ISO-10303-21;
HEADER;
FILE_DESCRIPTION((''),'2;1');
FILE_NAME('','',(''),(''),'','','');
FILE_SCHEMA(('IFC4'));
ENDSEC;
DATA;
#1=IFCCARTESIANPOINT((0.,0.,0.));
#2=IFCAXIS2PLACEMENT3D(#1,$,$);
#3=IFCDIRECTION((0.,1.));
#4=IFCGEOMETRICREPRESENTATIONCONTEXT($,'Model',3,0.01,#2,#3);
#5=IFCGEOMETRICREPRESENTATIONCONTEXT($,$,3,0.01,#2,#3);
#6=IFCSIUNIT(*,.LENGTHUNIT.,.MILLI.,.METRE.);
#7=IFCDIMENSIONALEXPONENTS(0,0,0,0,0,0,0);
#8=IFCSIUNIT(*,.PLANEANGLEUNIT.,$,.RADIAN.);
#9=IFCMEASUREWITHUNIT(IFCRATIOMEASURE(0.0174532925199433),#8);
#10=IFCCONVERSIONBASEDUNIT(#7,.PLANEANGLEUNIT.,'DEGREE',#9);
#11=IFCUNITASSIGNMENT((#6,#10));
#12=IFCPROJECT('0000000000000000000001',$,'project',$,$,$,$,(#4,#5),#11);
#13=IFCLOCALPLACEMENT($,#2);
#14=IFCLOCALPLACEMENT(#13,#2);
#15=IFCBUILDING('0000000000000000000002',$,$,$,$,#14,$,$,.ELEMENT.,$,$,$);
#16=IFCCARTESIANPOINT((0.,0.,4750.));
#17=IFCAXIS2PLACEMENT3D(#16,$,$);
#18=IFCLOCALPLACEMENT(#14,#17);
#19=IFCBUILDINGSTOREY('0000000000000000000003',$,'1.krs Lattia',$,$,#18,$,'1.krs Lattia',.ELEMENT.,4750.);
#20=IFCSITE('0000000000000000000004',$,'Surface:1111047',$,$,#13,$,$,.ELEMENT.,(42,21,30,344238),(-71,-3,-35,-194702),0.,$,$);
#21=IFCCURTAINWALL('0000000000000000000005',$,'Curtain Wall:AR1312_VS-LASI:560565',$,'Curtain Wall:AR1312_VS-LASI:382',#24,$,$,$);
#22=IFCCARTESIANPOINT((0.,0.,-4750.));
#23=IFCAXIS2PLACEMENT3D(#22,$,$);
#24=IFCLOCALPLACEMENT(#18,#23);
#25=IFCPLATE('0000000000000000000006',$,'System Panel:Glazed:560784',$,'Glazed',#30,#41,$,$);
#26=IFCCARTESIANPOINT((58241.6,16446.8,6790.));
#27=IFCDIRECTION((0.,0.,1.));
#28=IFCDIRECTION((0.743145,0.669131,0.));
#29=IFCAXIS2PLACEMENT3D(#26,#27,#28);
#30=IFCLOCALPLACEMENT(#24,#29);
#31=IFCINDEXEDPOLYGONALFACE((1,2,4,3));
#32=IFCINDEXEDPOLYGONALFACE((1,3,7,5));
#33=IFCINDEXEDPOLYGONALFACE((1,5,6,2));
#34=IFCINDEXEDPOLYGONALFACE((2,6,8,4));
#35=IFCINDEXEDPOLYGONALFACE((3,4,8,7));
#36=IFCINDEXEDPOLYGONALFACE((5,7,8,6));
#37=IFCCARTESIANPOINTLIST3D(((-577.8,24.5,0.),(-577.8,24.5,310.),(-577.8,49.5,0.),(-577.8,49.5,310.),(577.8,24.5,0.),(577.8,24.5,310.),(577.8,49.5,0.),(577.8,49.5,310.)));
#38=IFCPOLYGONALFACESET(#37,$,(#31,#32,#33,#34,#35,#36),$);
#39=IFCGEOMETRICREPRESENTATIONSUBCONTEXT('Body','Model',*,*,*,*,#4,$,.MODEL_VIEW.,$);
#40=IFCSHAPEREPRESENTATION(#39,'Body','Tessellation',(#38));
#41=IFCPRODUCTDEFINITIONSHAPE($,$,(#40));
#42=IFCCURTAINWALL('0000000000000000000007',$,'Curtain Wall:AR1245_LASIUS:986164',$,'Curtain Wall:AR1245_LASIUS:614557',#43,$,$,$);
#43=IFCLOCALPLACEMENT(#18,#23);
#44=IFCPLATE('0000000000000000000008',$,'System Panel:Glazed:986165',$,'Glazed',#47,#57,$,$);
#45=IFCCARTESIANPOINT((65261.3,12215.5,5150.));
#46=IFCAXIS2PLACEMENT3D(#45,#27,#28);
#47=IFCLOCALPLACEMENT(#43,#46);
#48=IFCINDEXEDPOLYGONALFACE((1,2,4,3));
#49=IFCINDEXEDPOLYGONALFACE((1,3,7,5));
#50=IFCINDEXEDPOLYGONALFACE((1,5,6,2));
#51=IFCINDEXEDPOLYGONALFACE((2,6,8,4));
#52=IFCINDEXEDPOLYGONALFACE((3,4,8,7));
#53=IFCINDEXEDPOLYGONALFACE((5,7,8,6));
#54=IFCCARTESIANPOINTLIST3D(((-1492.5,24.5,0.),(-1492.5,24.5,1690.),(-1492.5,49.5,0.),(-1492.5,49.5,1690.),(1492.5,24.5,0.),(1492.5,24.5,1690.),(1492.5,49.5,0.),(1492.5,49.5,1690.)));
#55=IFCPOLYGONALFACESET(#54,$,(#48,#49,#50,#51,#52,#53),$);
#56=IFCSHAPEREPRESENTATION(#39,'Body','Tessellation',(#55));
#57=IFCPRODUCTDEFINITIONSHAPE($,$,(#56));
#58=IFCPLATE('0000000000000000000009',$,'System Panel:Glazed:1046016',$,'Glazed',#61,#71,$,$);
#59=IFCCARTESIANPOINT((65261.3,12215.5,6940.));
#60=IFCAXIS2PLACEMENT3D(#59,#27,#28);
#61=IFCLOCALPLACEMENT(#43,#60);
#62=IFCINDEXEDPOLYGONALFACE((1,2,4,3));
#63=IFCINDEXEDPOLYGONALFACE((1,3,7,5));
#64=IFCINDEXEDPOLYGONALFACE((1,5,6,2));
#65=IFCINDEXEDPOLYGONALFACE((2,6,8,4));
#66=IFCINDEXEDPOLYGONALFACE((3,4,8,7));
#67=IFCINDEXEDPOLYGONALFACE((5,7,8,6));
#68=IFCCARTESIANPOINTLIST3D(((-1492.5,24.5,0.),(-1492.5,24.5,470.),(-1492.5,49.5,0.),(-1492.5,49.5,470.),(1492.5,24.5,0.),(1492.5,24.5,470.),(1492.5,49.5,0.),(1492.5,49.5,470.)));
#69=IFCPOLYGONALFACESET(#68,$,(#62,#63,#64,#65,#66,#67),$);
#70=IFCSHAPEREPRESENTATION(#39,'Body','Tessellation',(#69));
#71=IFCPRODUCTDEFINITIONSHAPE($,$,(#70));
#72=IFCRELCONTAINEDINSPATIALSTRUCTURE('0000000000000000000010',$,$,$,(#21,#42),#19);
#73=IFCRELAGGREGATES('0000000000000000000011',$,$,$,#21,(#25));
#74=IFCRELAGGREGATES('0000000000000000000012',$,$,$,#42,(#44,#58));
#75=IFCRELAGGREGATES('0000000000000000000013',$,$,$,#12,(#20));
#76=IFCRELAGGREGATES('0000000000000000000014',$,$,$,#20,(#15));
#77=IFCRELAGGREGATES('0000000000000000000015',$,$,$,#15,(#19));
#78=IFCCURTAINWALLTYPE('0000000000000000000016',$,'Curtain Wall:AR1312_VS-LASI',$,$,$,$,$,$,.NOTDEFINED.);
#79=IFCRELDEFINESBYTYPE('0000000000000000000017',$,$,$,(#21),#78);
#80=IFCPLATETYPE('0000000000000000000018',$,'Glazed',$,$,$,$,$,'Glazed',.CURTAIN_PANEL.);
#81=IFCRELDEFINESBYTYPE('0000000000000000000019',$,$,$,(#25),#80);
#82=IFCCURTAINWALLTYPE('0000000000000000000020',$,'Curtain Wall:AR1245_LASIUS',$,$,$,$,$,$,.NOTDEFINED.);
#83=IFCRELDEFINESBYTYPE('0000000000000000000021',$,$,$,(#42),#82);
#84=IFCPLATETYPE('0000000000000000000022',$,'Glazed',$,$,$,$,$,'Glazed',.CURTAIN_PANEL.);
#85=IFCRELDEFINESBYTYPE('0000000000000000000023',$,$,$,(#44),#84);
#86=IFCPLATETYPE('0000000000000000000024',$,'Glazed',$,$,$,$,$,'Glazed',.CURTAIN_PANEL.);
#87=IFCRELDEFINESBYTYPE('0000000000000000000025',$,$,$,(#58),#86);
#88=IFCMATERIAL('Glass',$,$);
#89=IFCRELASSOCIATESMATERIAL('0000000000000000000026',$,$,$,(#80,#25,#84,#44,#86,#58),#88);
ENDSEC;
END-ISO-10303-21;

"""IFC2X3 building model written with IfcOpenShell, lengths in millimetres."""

from ifc_helpers import new_model, entity, si_unit, converted_unit, direction, frame, frame_2d, origin, place, context, subcontext, project, spatial, rectangle, extrude, source, transform, mapped, material, type_object, type_shapes, element, aggregate, save


model = new_model("IFC2X3")

# Units and contexts
model_context = context("Model", 3, precision=0.01, world=origin(), true_north=direction((0.0, 1.0)))
context_of_model = context(None, 3, precision=0.01, world=origin(), true_north=direction((0.0, 1.0)))
body_context = subcontext(model_context, "Body", "Model", "MODEL_VIEW")
ifc_project = project(units=[si_unit("LENGTHUNIT", "METRE", prefix="MILLI"), converted_unit("PLANEANGLEUNIT", "DEGREE", entity("IfcRatioMeasure", 0.0174532925199433), si_unit("PLANEANGLEUNIT", "RADIAN"), dimensions=[0, 0, 0, 0, 0, 0, 0])], contexts=[model_context, context_of_model])

# Site, building, storey
site_placement = place(None, origin())
site = spatial("IfcSite", under=ifc_project, at=site_placement, Name="Surface:1111047", CompositionType="ELEMENT", RefLatitude=(42, 21, 30, 344238), RefLongitude=(-71, -3, -35, -194702), RefElevation=0.0)
building_placement = place(site_placement, origin())
building = spatial("IfcBuilding", under=site, at=building_placement, CompositionType="ELEMENT")
storey_placement = place(building_placement, frame((0.0, 0.0, 4750.0)))
storey = spatial("IfcBuildingStorey", under=building, at=storey_placement, Name="1.krs Lattia", LongName="1.krs Lattia", CompositionType="ELEMENT", Elevation=4750.0)

# Shared definitions
curtain_wall_type_1 = type_object("IfcCurtainWallType", Name="Curtain Wall:AR1312_VS-LASI", PredefinedType="NOTDEFINED")
ifc_material_1 = material(Name="Glass")

# Curtain walls, plates
curtain_wall_1_placement = place(storey_placement, frame((0.0, 0.0, -4750.0)))
curtain_wall_1 = element("IfcCurtainWall", 1, at=curtain_wall_1_placement, inside=storey, type_object=curtain_wall_type_1, Name="Curtain Wall:AR1312_VS-LASI:560565", ObjectType="Curtain Wall:AR1312_VS-LASI:382")
plate_type_1 = type_object("IfcPlateType", Name="Glazed", ElementType="Glazed", PredefinedType="CURTAIN_PANEL", material=ifc_material_1)
shared_shape_1 = source(origin(), body_context, "Body", "SweptSolid", [
    extrude(rectangle(XDim=25.0, YDim=1155.6, at=frame_2d((0.0, 0.0), x_axis=(1.0, 0.0))), frame((0.0, 37.0, 0.0), z_axis=(0.0, 0.0, 1.0), x_axis=(0.0, 1.0, 0.0)), (0.0, 0.0, 1.0), 310.0),
])
type_shapes(plate_type_1, [shared_shape_1])
plate_1_placement = place(curtain_wall_1_placement, frame((58241.6, 16446.8, 6790.0), z_axis=(0.0, 0.0, 1.0), x_axis=(0.743145, 0.669131, 0.0)))
plate_1 = element("IfcPlate", 2, at=plate_1_placement, type_object=plate_type_1, material=ifc_material_1, Name="System Panel:Glazed:560784", ObjectType="Glazed", context=body_context, shape_type="MappedRepresentation", body=[
    mapped(shared_shape_1, transform((0.0, 0.0, 0.0), scale=1.0)),
])
aggregate(curtain_wall_1, [plate_1])
curtain_wall_type_2 = type_object("IfcCurtainWallType", Name="Curtain Wall:AR1245_LASIUS", PredefinedType="NOTDEFINED")
curtain_wall_2_placement = place(storey_placement, frame((0.0, 0.0, -4750.0)))
curtain_wall_2 = element("IfcCurtainWall", 3, at=curtain_wall_2_placement, inside=storey, type_object=curtain_wall_type_2, Name="Curtain Wall:AR1245_LASIUS:986164", ObjectType="Curtain Wall:AR1245_LASIUS:614557")
plate_type_2 = type_object("IfcPlateType", Name="Glazed", ElementType="Glazed", PredefinedType="CURTAIN_PANEL", material=ifc_material_1)
shared_shape_2 = source(origin(), body_context, "Body", "SweptSolid", [
    extrude(rectangle(XDim=25.0, YDim=2985.0, at=frame_2d((0.0, 0.0), x_axis=(1.0, 0.0))), frame((0.0, 37.0, 0.0), z_axis=(0.0, 0.0, 1.0), x_axis=(0.0, 1.0, 0.0)), (0.0, 0.0, 1.0), 1690.0),
])
type_shapes(plate_type_2, [shared_shape_2])
plate_2_placement = place(curtain_wall_2_placement, frame((65261.3, 12215.5, 5150.0), z_axis=(0.0, 0.0, 1.0), x_axis=(0.743145, 0.669131, 0.0)))
plate_2 = element("IfcPlate", 4, at=plate_2_placement, type_object=plate_type_2, material=ifc_material_1, Name="System Panel:Glazed:986165", ObjectType="Glazed", context=body_context, shape_type="MappedRepresentation", body=[
    mapped(shared_shape_2, transform((0.0, 0.0, 0.0), scale=1.0)),
])
plate_type_3 = type_object("IfcPlateType", Name="Glazed", ElementType="Glazed", PredefinedType="CURTAIN_PANEL", material=ifc_material_1)
shared_shape_3 = source(origin(), body_context, "Body", "SweptSolid", [
    extrude(rectangle(XDim=25.0, YDim=2985.0, at=frame_2d((0.0, 0.0), x_axis=(1.0, 0.0))), frame((0.0, 37.0, 0.0), z_axis=(0.0, 0.0, 1.0), x_axis=(0.0, 1.0, 0.0)), (0.0, 0.0, 1.0), 470.0),
])
type_shapes(plate_type_3, [shared_shape_3])
plate_3_placement = place(curtain_wall_2_placement, frame((65261.3, 12215.5, 6940.0), z_axis=(0.0, 0.0, 1.0), x_axis=(0.743145, 0.669131, 0.0)))
plate_3 = element("IfcPlate", 5, at=plate_3_placement, type_object=plate_type_3, material=ifc_material_1, Name="System Panel:Glazed:1046016", ObjectType="Glazed", context=body_context, shape_type="MappedRepresentation", body=[
    mapped(shared_shape_3, transform((0.0, 0.0, 0.0), scale=1.0)),
])
aggregate(curtain_wall_2, [plate_2, plate_3])

save(model, "model.ifc")
